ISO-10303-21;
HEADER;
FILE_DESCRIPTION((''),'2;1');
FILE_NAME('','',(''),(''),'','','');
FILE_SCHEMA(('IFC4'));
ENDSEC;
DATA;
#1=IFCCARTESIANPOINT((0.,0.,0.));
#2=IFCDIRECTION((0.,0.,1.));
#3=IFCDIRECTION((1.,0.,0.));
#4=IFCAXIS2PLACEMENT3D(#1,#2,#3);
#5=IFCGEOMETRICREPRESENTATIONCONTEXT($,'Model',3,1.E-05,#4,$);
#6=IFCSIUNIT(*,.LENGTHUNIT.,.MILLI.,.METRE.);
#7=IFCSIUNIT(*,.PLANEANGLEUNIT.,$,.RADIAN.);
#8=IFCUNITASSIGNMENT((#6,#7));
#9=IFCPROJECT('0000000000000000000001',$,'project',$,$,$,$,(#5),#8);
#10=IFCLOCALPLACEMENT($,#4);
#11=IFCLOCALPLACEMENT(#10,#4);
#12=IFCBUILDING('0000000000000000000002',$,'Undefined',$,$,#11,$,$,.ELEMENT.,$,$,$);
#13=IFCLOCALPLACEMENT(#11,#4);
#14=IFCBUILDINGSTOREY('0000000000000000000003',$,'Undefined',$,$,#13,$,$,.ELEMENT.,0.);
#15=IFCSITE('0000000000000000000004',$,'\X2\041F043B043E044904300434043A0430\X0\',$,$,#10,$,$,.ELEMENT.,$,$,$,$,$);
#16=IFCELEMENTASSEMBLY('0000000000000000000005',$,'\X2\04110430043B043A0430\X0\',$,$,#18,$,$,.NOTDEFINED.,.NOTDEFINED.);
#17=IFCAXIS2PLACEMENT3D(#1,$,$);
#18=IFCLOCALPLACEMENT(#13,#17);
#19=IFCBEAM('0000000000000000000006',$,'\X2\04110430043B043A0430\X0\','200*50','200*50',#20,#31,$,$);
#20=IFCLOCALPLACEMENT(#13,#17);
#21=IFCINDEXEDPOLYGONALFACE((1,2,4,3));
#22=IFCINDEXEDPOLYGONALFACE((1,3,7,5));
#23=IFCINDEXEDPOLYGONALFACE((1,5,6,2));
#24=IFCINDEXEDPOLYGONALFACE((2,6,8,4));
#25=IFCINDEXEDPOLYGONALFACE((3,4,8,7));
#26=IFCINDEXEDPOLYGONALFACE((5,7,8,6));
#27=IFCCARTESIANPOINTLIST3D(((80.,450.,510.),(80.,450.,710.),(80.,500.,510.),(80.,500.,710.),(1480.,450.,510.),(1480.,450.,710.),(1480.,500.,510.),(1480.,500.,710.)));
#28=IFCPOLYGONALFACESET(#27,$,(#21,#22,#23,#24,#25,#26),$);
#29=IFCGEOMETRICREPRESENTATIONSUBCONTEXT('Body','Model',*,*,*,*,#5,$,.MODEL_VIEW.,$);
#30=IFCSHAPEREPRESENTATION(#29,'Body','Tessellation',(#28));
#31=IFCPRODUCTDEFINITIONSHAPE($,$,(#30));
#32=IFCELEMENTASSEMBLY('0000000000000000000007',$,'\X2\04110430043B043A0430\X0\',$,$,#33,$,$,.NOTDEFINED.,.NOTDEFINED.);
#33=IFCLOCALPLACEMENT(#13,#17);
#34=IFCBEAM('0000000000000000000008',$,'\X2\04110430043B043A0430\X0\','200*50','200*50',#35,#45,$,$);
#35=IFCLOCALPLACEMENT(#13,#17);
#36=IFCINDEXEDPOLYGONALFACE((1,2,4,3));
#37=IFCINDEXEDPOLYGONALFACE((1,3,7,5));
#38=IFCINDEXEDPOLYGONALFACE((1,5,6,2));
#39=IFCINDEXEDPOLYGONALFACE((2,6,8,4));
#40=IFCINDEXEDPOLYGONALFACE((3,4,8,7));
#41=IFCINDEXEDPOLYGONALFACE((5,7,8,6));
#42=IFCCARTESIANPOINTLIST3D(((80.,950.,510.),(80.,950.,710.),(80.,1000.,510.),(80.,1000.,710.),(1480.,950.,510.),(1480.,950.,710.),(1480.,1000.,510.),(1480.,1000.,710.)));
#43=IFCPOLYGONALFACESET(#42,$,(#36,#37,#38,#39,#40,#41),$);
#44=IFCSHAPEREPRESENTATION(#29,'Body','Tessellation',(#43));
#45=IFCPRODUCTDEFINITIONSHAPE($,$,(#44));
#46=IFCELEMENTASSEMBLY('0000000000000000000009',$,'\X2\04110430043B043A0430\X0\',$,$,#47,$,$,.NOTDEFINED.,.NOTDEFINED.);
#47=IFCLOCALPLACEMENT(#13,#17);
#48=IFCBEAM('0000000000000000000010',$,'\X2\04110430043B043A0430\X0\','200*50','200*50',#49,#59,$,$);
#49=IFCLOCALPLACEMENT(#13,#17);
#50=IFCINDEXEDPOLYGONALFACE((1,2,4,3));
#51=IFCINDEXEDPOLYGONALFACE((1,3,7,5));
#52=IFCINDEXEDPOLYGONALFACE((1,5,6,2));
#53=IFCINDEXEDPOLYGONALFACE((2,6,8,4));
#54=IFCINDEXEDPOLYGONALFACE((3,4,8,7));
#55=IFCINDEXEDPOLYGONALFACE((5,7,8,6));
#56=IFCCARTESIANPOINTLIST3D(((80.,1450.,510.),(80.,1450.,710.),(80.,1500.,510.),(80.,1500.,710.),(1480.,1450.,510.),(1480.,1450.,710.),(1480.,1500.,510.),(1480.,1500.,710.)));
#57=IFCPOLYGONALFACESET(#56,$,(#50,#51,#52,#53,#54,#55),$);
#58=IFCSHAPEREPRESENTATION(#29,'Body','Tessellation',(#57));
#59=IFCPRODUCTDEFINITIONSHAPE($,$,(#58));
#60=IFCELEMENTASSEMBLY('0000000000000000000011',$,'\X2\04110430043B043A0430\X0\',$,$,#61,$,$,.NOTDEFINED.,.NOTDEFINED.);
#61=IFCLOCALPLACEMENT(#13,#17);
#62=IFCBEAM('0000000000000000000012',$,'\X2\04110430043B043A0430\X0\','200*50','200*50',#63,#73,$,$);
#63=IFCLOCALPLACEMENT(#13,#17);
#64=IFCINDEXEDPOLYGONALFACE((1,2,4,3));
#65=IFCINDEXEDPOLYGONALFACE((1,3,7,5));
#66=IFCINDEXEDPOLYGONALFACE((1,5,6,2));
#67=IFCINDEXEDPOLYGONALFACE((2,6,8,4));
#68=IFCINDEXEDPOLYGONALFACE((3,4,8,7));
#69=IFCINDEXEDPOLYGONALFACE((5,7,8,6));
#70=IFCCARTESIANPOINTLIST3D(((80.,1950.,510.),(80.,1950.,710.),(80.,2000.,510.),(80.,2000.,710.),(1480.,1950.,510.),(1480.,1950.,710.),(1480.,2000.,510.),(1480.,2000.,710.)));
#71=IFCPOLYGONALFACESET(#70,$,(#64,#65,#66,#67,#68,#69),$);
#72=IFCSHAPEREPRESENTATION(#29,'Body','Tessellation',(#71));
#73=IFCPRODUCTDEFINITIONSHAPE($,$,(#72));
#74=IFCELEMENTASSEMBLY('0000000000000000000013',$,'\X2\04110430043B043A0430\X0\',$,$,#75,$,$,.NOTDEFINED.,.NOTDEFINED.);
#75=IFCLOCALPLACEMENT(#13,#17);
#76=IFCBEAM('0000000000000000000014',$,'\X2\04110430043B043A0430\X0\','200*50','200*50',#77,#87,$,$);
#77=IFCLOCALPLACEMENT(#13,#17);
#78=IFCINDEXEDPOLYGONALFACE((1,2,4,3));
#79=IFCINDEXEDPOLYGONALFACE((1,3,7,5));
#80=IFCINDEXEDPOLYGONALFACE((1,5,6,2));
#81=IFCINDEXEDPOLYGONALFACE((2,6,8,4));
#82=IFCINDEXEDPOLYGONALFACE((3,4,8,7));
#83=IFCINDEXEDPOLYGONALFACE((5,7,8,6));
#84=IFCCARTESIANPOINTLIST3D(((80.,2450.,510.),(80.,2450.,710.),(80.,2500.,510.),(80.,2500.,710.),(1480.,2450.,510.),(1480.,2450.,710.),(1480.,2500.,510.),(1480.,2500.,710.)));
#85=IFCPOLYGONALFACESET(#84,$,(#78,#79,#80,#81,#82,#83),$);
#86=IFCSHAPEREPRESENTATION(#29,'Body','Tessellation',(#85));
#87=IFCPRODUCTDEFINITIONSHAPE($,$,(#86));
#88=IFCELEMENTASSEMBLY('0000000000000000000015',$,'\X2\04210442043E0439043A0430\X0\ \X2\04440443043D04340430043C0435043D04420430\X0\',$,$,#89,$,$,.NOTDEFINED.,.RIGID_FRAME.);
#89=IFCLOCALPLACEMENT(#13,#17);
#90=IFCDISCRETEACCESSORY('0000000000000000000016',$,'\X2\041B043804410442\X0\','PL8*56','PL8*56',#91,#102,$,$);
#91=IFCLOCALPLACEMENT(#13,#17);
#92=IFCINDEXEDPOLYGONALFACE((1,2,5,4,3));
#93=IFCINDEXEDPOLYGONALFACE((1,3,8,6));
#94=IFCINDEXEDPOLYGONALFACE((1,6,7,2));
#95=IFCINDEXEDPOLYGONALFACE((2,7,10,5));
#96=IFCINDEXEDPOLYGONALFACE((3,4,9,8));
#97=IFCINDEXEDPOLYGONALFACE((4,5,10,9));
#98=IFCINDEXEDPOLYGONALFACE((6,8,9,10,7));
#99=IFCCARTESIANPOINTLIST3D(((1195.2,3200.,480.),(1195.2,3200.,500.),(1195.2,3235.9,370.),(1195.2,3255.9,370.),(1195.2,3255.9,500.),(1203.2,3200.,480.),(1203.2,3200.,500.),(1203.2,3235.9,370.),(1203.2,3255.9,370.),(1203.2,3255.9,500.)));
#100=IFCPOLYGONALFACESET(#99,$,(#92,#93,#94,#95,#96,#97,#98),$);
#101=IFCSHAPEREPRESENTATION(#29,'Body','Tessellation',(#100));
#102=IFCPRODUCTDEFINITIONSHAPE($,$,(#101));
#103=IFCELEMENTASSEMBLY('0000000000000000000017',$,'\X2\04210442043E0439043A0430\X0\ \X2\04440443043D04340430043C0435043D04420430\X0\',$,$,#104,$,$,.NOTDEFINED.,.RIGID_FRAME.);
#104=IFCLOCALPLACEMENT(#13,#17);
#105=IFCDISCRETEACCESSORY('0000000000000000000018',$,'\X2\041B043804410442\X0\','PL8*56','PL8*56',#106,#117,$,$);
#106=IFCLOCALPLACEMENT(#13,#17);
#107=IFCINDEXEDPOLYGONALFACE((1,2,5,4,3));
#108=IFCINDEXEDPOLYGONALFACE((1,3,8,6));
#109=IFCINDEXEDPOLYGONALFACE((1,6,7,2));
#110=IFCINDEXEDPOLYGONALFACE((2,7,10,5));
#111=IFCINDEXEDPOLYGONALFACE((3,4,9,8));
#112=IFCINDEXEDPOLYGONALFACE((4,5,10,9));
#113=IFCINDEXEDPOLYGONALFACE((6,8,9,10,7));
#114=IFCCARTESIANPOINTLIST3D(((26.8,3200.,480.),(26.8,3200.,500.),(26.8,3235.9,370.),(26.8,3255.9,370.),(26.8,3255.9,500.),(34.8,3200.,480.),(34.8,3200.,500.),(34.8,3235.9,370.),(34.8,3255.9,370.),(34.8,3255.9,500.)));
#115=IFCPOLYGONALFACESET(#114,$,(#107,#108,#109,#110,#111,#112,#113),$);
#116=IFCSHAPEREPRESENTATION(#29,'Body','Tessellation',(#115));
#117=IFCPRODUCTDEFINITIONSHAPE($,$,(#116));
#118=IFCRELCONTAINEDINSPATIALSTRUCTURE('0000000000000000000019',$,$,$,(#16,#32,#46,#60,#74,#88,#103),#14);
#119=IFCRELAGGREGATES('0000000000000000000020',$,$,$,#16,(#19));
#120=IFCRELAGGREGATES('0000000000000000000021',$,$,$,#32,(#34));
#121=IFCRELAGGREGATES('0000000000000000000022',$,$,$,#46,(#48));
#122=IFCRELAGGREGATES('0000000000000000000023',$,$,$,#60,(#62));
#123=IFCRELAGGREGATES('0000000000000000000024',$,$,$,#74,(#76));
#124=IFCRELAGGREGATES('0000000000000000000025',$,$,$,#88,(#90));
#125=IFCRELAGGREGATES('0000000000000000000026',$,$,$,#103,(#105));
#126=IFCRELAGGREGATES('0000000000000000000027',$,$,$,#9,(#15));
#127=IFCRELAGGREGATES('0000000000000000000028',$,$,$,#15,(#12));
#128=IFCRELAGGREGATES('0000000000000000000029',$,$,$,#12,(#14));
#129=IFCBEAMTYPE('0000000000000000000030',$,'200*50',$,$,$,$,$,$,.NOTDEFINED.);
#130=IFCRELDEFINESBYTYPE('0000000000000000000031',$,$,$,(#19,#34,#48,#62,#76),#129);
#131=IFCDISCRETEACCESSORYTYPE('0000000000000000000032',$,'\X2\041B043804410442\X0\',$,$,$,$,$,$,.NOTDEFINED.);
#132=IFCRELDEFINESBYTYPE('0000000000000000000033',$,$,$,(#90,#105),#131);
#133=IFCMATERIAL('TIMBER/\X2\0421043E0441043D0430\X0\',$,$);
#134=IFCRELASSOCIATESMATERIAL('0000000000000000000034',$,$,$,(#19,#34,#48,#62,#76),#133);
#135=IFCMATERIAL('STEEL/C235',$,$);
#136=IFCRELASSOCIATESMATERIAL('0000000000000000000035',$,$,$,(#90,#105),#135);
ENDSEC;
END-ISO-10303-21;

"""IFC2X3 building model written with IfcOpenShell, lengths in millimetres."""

from ifc_helpers import new_model, si_unit, frame, origin_with_axes, origin_2d_with_axis, place, context, subcontext, project, spatial, polyline, rectangle, outline, extrude, material, type_object, element, aggregate, save


model = new_model("IFC2X3")

# Units and contexts
model_context = context("Model", 3, precision=1e-05, world=origin_with_axes())
body_context = subcontext(model_context, "Body", "Model", "MODEL_VIEW")
ifc_project = project(units=[si_unit("LENGTHUNIT", "METRE", prefix="MILLI"), si_unit("PLANEANGLEUNIT", "RADIAN")], contexts=[model_context])

# Site, building, storey
site_placement = place(None, origin_with_axes())
site = spatial("IfcSite", under=ifc_project, at=site_placement, Name="Площадка", CompositionType="ELEMENT")
building_placement = place(site_placement, origin_with_axes())
building = spatial("IfcBuilding", under=site, at=building_placement, Name="Undefined", CompositionType="ELEMENT")
storey_placement = place(building_placement, origin_with_axes())
storey = spatial("IfcBuildingStorey", under=building, at=storey_placement, Name="Undefined", CompositionType="ELEMENT", Elevation=0.0)

# Shared definitions
ifc_material_1 = material(Name="TIMBER/Сосна")

# Element assemblies, beams
assembly_1_placement = place(storey_placement, origin_with_axes())
assembly_1 = element("IfcElementAssembly", 1, at=assembly_1_placement, inside=storey, Name="Балка", AssemblyPlace="NOTDEFINED", PredefinedType="NOTDEFINED")
beam_type_1 = type_object("IfcBeamType", Name="200*50", PredefinedType="NOTDEFINED")
beam_1_placement = place(assembly_1_placement, frame((1480.0, 475.0, 610.0), z_axis=(0.0, 0.0, -1.0), x_axis=(-1.0, 0.0, 0.0)))
beam_1 = element("IfcBeam", 2, at=beam_1_placement, type_object=beam_type_1, material=ifc_material_1, Name="Балка", Description="200*50", ObjectType="200*50", context=body_context, shape_type="SweptSolid", body=[
    extrude(rectangle(XDim=50.0, YDim=200.0, at=origin_2d_with_axis()), frame((1400.0, 0.0, 0.0), z_axis=(-1.0, 0.0, 0.0), x_axis=(0.0, -1.0, 0.0)), (0.0, 0.0, 1.0), 1400.0),
])
aggregate(assembly_1, [beam_1])
assembly_2_placement = place(storey_placement, origin_with_axes())
assembly_2 = element("IfcElementAssembly", 3, at=assembly_2_placement, inside=storey, Name="Балка", AssemblyPlace="NOTDEFINED", PredefinedType="NOTDEFINED")
beam_2_placement = place(assembly_2_placement, frame((1480.0, 975.0, 610.0), z_axis=(0.0, 0.0, -1.0), x_axis=(-1.0, 0.0, 0.0)))
beam_2 = element("IfcBeam", 4, at=beam_2_placement, type_object=beam_type_1, material=ifc_material_1, Name="Балка", Description="200*50", ObjectType="200*50", context=body_context, shape_type="SweptSolid", body=[
    extrude(rectangle(XDim=50.0, YDim=200.0, at=origin_2d_with_axis()), frame((1400.0, 0.0, 0.0), z_axis=(-1.0, 0.0, 0.0), x_axis=(0.0, -1.0, 0.0)), (0.0, 0.0, 1.0), 1400.0),
])
aggregate(assembly_2, [beam_2])
assembly_3_placement = place(storey_placement, origin_with_axes())
assembly_3 = element("IfcElementAssembly", 5, at=assembly_3_placement, inside=storey, Name="Балка", AssemblyPlace="NOTDEFINED", PredefinedType="NOTDEFINED")
beam_3_placement = place(assembly_3_placement, frame((1480.0, 1475.0, 610.0), z_axis=(0.0, 0.0, -1.0), x_axis=(-1.0, 0.0, 0.0)))
beam_3 = element("IfcBeam", 6, at=beam_3_placement, type_object=beam_type_1, material=ifc_material_1, Name="Балка", Description="200*50", ObjectType="200*50", context=body_context, shape_type="SweptSolid", body=[
    extrude(rectangle(XDim=50.0, YDim=200.0, at=origin_2d_with_axis()), frame((1400.0, 0.0, 0.0), z_axis=(-1.0, 0.0, 0.0), x_axis=(0.0, -1.0, 0.0)), (0.0, 0.0, 1.0), 1400.0),
])
aggregate(assembly_3, [beam_3])
assembly_4_placement = place(storey_placement, origin_with_axes())
assembly_4 = element("IfcElementAssembly", 7, at=assembly_4_placement, inside=storey, Name="Балка", AssemblyPlace="NOTDEFINED", PredefinedType="NOTDEFINED")
beam_4_placement = place(assembly_4_placement, frame((1480.0, 1975.0, 610.0), z_axis=(0.0, 0.0, -1.0), x_axis=(-1.0, 0.0, 0.0)))
beam_4 = element("IfcBeam", 8, at=beam_4_placement, type_object=beam_type_1, material=ifc_material_1, Name="Балка", Description="200*50", ObjectType="200*50", context=body_context, shape_type="SweptSolid", body=[
    extrude(rectangle(XDim=50.0, YDim=200.0, at=origin_2d_with_axis()), frame((1400.0, 0.0, 0.0), z_axis=(-1.0, 0.0, 0.0), x_axis=(0.0, -1.0, 0.0)), (0.0, 0.0, 1.0), 1400.0),
])
aggregate(assembly_4, [beam_4])
assembly_5_placement = place(storey_placement, origin_with_axes())
assembly_5 = element("IfcElementAssembly", 9, at=assembly_5_placement, inside=storey, Name="Балка", AssemblyPlace="NOTDEFINED", PredefinedType="NOTDEFINED")
beam_5_placement = place(assembly_5_placement, frame((1480.0, 2475.0, 610.0), z_axis=(0.0, 0.0, -1.0), x_axis=(-1.0, 0.0, 0.0)))
beam_5 = element("IfcBeam", 10, at=beam_5_placement, type_object=beam_type_1, material=ifc_material_1, Name="Балка", Description="200*50", ObjectType="200*50", context=body_context, shape_type="SweptSolid", body=[
    extrude(rectangle(XDim=50.0, YDim=200.0, at=origin_2d_with_axis()), frame((1400.0, 0.0, 0.0), z_axis=(-1.0, 0.0, 0.0), x_axis=(0.0, -1.0, 0.0)), (0.0, 0.0, 1.0), 1400.0),
])
aggregate(assembly_5, [beam_5])

# Element assemblies, discrete accessories
assembly_6_placement = place(storey_placement, origin_with_axes())
assembly_6 = element("IfcElementAssembly", 11, at=assembly_6_placement, inside=storey, Name="Стойка фундамента", AssemblyPlace="NOTDEFINED", PredefinedType="RIGID_FRAME")
ifc_material_2 = material(Name="STEEL/C235")
discrete_accessory_type = type_object("IfcDiscreteAccessoryType", Name="Лист")
discrete_accessory_1_placement = place(assembly_6_placement, frame((1199.2, 3255.9, 500.0), z_axis=(1.0, 0.0, 0.0), x_axis=(0.0, -1.0, 0.0)))
discrete_accessory_1 = element("IfcDiscreteAccessory", 12, at=discrete_accessory_1_placement, type_object=discrete_accessory_type, material=ifc_material_2, Name="Лист", Description="PL8*56", ObjectType="PL8*56", context=body_context, shape_type="SweptSolid", body=[
    extrude(outline(polyline([(0.0, 0.0), (55.9, 0.0), (55.9, 20.0), (20.0, 130.0), (0.0, 130.0), (0.0, 0.0)])), frame((0.0, 0.0, -4.0), z_axis=(0.0, 0.0, 1.0), x_axis=(1.0, 0.0, 0.0)), (0.0, 0.0, 1.0), 8.0),
])
aggregate(assembly_6, [discrete_accessory_1])
assembly_7_placement = place(storey_placement, origin_with_axes())
assembly_7 = element("IfcElementAssembly", 13, at=assembly_7_placement, inside=storey, Name="Стойка фундамента", AssemblyPlace="NOTDEFINED", PredefinedType="RIGID_FRAME")
discrete_accessory_2_placement = place(assembly_7_placement, frame((30.8, 3255.9, 500.0), z_axis=(1.0, 0.0, 0.0), x_axis=(0.0, -1.0, 0.0)))
discrete_accessory_2 = element("IfcDiscreteAccessory", 14, at=discrete_accessory_2_placement, type_object=discrete_accessory_type, material=ifc_material_2, Name="Лист", Description="PL8*56", ObjectType="PL8*56", context=body_context, shape_type="SweptSolid", body=[
    extrude(outline(polyline([(0.0, 0.0), (55.9, 0.0), (55.9, 20.0), (20.0, 130.0), (0.0, 130.0), (0.0, 0.0)])), frame((0.0, 0.0, -4.0), z_axis=(0.0, 0.0, 1.0), x_axis=(1.0, 0.0, 0.0)), (0.0, 0.0, 1.0), 8.0),
])
aggregate(assembly_7, [discrete_accessory_2])

save(model, "model.ifc")
